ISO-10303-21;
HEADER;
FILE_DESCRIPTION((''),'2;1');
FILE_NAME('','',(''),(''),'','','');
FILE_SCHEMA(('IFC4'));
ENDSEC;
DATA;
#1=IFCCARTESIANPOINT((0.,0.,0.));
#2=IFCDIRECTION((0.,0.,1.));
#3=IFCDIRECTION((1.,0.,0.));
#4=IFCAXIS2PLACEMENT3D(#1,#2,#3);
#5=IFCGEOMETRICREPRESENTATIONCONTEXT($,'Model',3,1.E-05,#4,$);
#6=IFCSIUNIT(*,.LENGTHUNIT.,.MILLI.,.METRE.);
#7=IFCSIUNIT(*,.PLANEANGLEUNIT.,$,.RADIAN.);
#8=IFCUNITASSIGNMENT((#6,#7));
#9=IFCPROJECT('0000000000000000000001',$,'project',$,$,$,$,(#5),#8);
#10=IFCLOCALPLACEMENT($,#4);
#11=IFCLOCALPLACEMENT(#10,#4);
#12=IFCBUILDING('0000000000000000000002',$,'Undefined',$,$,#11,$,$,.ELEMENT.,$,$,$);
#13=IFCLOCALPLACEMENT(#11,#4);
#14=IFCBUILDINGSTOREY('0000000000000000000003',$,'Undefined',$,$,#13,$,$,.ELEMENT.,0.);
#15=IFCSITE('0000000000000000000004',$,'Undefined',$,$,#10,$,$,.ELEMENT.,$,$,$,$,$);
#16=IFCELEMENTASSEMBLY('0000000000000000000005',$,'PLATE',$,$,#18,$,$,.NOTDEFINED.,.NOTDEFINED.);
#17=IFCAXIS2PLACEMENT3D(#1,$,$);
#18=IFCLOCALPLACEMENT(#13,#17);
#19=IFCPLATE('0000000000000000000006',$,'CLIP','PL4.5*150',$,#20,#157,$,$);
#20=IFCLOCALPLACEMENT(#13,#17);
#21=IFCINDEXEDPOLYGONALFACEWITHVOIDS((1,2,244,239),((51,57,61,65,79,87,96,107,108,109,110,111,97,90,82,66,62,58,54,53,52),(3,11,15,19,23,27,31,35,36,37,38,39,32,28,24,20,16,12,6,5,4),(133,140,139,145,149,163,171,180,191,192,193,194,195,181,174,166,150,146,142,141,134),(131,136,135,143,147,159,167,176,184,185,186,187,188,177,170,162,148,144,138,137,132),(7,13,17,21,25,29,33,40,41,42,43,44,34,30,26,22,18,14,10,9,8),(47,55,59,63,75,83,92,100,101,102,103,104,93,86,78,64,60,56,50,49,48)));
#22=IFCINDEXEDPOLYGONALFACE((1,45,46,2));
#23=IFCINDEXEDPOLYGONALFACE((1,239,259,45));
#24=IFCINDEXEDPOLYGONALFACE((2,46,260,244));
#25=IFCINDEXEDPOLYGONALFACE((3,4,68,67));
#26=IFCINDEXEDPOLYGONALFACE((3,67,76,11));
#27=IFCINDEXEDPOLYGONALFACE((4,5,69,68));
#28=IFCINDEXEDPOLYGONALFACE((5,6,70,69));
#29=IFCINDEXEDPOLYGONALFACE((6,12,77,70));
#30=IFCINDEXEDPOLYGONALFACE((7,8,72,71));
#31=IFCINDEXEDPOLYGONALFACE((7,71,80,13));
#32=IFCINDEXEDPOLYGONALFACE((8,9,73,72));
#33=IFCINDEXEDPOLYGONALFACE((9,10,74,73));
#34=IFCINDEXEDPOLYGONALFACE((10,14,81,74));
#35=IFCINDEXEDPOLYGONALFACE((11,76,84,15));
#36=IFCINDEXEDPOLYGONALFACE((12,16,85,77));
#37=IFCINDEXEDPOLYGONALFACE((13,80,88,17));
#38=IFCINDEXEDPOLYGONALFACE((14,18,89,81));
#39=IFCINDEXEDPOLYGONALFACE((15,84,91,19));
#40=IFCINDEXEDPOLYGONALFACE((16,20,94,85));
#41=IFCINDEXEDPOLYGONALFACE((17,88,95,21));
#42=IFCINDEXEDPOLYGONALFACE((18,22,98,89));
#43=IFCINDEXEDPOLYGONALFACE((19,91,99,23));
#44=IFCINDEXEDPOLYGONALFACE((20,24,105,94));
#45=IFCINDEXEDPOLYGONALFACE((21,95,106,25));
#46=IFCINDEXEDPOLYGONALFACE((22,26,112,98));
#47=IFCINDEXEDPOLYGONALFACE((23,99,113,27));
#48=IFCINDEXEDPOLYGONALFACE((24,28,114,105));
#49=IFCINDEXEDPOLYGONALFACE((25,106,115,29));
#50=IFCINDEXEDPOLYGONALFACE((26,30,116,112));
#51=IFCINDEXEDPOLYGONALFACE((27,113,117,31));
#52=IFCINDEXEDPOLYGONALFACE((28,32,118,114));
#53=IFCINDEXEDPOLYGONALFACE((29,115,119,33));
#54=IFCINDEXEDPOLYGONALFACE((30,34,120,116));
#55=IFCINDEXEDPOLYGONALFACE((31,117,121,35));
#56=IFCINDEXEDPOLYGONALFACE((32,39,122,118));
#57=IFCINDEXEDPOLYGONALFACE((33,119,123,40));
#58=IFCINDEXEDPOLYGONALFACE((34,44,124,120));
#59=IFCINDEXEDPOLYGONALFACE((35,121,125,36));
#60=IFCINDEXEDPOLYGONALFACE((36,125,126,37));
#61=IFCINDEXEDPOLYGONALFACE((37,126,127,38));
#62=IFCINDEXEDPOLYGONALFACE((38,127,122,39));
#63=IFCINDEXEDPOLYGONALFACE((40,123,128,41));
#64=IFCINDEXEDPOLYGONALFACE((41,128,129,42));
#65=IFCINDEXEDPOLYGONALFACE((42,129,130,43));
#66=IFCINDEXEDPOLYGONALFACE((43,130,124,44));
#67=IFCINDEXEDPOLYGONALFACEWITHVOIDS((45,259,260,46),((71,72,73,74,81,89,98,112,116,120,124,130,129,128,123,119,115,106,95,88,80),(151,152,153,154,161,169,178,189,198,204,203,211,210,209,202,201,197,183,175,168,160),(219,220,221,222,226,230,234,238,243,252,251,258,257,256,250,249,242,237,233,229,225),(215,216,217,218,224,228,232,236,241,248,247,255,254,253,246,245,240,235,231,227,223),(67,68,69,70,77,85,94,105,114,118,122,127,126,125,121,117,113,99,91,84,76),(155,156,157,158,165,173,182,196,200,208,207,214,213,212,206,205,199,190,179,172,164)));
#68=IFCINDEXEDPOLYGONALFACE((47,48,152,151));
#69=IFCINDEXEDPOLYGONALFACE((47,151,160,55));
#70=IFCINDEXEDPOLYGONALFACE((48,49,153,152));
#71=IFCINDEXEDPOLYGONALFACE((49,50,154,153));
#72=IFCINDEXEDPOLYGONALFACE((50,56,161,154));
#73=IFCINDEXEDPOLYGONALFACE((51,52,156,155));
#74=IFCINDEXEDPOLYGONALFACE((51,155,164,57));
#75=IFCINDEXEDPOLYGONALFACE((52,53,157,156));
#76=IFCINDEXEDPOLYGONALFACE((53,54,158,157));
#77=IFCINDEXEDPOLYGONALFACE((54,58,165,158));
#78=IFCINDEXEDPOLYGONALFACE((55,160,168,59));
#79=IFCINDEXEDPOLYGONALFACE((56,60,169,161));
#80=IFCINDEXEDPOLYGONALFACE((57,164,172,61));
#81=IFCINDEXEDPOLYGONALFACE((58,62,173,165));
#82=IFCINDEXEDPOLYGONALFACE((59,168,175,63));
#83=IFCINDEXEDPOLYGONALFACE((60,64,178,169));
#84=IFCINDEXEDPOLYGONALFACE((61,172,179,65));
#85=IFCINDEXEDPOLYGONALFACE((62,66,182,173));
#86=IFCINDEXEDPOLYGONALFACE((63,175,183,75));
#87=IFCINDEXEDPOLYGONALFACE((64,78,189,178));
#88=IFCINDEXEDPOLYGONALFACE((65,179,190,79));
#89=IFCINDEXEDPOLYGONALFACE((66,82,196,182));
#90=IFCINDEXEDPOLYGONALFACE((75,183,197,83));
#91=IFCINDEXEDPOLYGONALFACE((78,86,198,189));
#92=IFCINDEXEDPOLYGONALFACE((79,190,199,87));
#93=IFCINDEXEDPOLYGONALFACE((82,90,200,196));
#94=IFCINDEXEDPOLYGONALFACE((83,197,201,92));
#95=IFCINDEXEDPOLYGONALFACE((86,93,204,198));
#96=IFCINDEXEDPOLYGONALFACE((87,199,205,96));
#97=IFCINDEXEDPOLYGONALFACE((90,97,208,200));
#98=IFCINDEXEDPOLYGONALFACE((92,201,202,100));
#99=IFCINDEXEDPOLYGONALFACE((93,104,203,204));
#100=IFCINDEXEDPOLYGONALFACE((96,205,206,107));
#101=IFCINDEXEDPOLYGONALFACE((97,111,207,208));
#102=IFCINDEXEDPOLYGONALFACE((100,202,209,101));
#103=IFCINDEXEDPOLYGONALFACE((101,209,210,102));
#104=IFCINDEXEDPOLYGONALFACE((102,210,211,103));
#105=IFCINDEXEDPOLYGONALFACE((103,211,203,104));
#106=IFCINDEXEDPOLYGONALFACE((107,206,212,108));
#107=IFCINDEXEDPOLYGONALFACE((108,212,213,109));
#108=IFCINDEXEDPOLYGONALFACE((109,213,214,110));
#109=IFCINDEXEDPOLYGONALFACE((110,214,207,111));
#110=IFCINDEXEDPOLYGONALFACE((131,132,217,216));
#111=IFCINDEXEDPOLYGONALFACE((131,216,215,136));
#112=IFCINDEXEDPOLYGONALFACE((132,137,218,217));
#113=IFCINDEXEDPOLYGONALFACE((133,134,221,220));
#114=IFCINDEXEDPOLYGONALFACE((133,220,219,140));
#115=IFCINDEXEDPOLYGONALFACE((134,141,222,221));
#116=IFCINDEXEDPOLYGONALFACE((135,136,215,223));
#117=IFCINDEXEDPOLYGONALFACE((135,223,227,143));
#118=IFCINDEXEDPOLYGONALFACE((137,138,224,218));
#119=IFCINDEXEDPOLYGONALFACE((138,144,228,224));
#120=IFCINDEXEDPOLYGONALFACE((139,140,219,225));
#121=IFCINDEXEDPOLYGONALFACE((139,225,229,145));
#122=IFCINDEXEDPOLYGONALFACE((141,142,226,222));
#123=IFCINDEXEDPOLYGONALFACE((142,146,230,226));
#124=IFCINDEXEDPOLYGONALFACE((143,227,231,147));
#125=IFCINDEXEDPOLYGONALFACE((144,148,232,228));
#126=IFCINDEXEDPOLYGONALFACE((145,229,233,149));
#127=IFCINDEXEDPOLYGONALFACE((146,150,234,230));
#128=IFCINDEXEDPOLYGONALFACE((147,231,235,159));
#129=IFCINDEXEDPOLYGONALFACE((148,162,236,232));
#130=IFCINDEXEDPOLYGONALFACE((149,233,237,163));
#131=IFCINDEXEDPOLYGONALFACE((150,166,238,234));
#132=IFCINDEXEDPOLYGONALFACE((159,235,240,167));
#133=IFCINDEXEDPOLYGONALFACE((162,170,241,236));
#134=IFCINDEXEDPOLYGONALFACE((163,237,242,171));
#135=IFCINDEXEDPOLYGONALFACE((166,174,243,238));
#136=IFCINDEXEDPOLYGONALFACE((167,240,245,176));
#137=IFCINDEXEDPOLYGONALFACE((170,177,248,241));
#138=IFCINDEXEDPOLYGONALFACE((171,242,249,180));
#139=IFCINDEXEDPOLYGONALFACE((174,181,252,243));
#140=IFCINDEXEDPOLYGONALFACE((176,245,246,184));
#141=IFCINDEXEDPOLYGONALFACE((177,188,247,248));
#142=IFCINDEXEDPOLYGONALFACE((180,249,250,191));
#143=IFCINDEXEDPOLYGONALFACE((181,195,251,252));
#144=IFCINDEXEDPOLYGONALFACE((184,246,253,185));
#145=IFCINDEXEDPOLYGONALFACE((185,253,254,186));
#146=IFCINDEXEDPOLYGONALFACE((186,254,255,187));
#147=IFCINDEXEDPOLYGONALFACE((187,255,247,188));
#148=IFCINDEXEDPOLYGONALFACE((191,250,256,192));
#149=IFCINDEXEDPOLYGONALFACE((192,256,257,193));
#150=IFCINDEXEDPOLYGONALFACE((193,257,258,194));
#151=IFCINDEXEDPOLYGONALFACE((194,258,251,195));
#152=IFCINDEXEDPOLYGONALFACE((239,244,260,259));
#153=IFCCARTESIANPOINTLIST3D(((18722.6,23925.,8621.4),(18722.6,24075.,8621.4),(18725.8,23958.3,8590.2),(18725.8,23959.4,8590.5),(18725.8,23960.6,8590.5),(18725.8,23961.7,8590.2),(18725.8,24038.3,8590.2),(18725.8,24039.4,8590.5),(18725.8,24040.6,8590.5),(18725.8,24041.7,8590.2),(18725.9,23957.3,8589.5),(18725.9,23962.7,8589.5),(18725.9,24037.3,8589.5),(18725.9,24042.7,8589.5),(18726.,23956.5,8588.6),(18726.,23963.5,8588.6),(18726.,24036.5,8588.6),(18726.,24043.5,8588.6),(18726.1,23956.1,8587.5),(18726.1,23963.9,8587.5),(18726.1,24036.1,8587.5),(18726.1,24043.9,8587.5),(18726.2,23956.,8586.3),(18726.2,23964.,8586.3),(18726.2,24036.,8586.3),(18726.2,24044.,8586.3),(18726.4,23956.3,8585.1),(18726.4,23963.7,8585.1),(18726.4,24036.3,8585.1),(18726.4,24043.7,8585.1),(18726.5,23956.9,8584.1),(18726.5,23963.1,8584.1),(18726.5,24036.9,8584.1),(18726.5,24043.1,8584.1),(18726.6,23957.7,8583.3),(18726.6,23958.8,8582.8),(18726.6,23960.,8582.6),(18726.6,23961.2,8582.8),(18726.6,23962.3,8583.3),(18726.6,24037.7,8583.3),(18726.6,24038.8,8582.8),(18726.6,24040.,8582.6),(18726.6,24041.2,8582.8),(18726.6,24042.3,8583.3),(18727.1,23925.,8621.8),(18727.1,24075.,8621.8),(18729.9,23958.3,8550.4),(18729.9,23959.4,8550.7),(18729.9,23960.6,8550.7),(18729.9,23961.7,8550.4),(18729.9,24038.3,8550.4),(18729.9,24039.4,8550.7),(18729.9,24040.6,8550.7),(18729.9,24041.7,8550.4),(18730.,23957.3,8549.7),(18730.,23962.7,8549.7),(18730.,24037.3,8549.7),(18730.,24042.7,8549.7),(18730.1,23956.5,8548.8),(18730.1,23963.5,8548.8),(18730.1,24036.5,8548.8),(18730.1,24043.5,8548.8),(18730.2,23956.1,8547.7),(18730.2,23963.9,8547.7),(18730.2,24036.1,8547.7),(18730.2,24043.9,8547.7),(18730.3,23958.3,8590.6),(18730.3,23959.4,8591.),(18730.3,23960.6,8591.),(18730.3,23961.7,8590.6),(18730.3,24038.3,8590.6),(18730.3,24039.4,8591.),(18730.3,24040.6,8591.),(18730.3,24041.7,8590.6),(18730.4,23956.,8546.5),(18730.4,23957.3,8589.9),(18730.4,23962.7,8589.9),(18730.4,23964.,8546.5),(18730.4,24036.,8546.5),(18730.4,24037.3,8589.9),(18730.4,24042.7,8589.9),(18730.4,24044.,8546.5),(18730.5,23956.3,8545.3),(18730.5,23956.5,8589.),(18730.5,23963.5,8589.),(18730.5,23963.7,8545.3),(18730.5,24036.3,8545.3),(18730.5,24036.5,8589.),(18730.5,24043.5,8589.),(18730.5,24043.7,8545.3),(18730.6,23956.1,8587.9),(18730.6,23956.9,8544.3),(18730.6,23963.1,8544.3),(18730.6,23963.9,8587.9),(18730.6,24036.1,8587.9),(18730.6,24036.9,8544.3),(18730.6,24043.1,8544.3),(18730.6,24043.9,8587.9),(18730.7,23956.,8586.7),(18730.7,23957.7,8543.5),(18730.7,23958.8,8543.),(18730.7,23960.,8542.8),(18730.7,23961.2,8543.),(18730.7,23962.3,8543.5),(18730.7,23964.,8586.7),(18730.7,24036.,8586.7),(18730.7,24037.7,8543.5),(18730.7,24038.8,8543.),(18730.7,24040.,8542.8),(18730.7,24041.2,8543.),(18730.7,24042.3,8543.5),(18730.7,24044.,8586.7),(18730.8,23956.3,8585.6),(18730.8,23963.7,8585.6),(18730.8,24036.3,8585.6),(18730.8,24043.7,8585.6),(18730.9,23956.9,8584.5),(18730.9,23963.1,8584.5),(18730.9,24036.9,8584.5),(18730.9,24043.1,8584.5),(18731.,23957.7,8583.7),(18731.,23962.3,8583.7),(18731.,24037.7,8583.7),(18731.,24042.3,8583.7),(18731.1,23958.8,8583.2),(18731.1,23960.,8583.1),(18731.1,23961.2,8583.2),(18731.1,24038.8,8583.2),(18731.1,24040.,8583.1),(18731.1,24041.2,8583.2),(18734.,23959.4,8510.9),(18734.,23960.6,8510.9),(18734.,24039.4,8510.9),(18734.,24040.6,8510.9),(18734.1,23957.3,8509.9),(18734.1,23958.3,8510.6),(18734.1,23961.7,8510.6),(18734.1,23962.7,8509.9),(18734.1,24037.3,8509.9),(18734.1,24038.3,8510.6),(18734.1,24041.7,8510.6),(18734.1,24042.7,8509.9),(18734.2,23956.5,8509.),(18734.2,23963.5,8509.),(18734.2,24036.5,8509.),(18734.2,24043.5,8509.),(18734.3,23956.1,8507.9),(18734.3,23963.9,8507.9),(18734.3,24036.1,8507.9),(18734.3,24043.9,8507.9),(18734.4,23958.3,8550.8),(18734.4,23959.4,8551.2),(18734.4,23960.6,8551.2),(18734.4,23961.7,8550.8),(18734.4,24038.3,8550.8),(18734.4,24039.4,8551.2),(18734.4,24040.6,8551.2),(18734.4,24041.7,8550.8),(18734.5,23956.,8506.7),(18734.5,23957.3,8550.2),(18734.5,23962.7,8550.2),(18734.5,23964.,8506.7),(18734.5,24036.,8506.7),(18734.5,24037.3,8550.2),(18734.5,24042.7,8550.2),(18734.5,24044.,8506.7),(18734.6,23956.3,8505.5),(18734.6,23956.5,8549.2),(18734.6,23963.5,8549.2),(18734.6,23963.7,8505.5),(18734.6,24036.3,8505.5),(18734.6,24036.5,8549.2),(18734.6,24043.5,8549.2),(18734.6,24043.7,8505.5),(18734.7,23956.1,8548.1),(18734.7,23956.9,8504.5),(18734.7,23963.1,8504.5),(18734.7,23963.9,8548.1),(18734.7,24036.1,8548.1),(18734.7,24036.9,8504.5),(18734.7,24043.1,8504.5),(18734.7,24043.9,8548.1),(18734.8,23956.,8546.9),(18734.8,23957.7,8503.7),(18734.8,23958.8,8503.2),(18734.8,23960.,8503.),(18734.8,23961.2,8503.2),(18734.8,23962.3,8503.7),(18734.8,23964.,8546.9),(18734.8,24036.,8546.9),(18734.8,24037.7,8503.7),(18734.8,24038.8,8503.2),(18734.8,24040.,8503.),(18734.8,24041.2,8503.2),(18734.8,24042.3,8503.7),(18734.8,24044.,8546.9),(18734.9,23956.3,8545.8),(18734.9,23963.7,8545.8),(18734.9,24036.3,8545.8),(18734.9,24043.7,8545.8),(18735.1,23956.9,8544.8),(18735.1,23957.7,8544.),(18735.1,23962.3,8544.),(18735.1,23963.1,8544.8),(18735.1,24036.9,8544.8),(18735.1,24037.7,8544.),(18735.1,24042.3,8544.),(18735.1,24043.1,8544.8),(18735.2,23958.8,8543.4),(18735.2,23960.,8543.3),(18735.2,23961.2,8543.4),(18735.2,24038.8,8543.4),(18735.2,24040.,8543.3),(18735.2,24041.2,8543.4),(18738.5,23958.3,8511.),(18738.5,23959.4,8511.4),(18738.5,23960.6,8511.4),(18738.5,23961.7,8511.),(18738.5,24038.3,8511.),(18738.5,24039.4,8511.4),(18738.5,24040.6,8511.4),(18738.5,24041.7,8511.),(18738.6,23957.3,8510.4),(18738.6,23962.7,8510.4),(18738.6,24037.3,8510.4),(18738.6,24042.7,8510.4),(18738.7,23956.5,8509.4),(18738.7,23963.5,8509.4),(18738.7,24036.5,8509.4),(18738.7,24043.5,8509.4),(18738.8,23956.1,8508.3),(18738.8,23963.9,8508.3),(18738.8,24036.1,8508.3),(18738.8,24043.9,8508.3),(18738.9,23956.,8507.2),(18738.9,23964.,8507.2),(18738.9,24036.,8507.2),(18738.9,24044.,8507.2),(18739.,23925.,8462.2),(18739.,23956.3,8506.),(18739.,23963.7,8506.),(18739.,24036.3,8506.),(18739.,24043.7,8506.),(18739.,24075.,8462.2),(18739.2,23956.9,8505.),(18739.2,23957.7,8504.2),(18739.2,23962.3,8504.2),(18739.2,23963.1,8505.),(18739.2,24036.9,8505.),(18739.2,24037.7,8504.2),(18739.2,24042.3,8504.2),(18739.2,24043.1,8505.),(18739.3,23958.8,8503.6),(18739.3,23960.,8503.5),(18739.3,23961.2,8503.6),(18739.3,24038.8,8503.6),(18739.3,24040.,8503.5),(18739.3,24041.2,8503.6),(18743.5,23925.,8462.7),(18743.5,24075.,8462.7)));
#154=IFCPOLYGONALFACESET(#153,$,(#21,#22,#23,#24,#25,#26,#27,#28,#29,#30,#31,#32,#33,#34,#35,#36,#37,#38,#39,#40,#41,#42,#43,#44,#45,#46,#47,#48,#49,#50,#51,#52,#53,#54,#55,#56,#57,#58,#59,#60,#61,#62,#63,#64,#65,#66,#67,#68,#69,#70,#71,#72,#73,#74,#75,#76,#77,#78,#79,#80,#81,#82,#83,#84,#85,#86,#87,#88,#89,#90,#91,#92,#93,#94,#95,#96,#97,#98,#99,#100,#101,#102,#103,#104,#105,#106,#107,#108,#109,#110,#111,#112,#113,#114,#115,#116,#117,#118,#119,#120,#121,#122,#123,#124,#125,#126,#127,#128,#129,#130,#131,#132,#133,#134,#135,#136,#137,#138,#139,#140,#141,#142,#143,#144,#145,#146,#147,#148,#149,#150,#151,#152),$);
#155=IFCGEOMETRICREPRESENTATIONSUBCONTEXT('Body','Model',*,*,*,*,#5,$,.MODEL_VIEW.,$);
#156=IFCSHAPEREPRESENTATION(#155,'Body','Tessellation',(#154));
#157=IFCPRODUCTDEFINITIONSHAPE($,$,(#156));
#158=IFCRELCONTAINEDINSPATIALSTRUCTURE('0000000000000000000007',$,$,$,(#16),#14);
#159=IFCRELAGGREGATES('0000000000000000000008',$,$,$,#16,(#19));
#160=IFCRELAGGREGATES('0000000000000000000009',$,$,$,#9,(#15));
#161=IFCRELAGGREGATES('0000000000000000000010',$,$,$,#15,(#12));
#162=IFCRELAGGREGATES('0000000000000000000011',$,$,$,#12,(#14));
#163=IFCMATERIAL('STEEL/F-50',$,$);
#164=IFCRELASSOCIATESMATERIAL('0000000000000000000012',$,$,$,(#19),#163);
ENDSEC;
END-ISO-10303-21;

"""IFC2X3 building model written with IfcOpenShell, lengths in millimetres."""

from ifc_helpers import new_model, si_unit, frame, origin_with_axes, origin_2d_with_axis, place, context, subcontext, project, spatial, polyline, circle, outline, extrude, source, transform, mapped, material, element, aggregate, save


model = new_model("IFC2X3")

# Units and contexts
model_context = context("Model", 3, precision=1e-05, world=origin_with_axes())
body_context = subcontext(model_context, "Body", "Model", "MODEL_VIEW")
ifc_project = project(units=[si_unit("LENGTHUNIT", "METRE", prefix="MILLI"), si_unit("PLANEANGLEUNIT", "RADIAN")], contexts=[model_context])

# Site, building, storey
site_placement = place(None, origin_with_axes())
site = spatial("IfcSite", under=ifc_project, at=site_placement, Name="Undefined", CompositionType="ELEMENT")
building_placement = place(site_placement, origin_with_axes())
building = spatial("IfcBuilding", under=site, at=building_placement, Name="Undefined", CompositionType="ELEMENT")
storey_placement = place(building_placement, origin_with_axes())
storey = spatial("IfcBuildingStorey", under=building, at=storey_placement, Name="Undefined", CompositionType="ELEMENT", Elevation=0.0)

# Shared definitions
ifc_material_1 = material(Name="STEEL/F-50")

# Element assembly, plate, openings
assembly_1_placement = place(storey_placement, origin_with_axes())
assembly_1 = element("IfcElementAssembly", 1, at=assembly_1_placement, inside=storey, Name="PLATE", AssemblyPlace="NOTDEFINED", PredefinedType="NOTDEFINED")
shared_shape_1 = source(origin_with_axes(), body_context, "Body", "SweptSolid", [
    extrude(circle(Radius=4.0, at=origin_2d_with_axis()), frame((0.0, -4.6, 0.0), z_axis=(0.0, 1.0, 0.0), x_axis=(1.0, 0.0, 0.0)), (0.0, 0.0, 1.0), 4.7),
])
plate_1_placement = place(assembly_1_placement, frame((18724.9, 23925.0, 8621.6), z_axis=(0.994727, 0.0, 0.102562), x_axis=(0.102562, 0.0, -0.994727)))
plate_1 = element("IfcPlate", 2, at=plate_1_placement, material=ifc_material_1, Name="CLIP", Description="PL4.5*150", context=body_context, shape_type="SweptSolid", body=[
    extrude(outline(polyline([(0.0, 0.0), (160.0, 0.0), (160.0, 150.0), (0.0, 150.0), (0.0, 0.0)])), frame((0.0, 0.0, -2.2), z_axis=(0.0, 0.0, 1.0), x_axis=(1.0, 0.0, 0.0)), (0.0, 0.0, 1.0), 4.5),
])
opening_1_placement = place(assembly_1_placement, frame((18726.2, 24040.0, 8586.6), z_axis=(0.0, 1.0, 0.0), x_axis=(0.102562, 0.0, -0.994727)))
element("IfcOpeningElement", 3, at=opening_1_placement, cuts=plate_1, ObjectType="Opening", context=body_context, shape_type="MappedRepresentation", body=[
    mapped(shared_shape_1, transform((0.0, 0.0, 0.0))),
    mapped(shared_shape_1, transform((40.0, 0.0, 0.0))),
    mapped(shared_shape_1, transform((80.0, 0.0, 0.0))),
])
opening_2_placement = place(assembly_1_placement, frame((18726.2, 23960.0, 8586.6), z_axis=(0.0, 1.0, 0.0), x_axis=(0.102562, 0.0, -0.994727)))
element("IfcOpeningElement", 4, at=opening_2_placement, cuts=plate_1, ObjectType="Opening", context=body_context, shape_type="MappedRepresentation", body=[
    mapped(shared_shape_1, transform((0.0, 0.0, 0.0))),
    mapped(shared_shape_1, transform((40.0, 0.0, 0.0))),
    mapped(shared_shape_1, transform((80.0, 0.0, 0.0))),
])

aggregate(assembly_1, [plate_1])

save(model, "model.ifc")
